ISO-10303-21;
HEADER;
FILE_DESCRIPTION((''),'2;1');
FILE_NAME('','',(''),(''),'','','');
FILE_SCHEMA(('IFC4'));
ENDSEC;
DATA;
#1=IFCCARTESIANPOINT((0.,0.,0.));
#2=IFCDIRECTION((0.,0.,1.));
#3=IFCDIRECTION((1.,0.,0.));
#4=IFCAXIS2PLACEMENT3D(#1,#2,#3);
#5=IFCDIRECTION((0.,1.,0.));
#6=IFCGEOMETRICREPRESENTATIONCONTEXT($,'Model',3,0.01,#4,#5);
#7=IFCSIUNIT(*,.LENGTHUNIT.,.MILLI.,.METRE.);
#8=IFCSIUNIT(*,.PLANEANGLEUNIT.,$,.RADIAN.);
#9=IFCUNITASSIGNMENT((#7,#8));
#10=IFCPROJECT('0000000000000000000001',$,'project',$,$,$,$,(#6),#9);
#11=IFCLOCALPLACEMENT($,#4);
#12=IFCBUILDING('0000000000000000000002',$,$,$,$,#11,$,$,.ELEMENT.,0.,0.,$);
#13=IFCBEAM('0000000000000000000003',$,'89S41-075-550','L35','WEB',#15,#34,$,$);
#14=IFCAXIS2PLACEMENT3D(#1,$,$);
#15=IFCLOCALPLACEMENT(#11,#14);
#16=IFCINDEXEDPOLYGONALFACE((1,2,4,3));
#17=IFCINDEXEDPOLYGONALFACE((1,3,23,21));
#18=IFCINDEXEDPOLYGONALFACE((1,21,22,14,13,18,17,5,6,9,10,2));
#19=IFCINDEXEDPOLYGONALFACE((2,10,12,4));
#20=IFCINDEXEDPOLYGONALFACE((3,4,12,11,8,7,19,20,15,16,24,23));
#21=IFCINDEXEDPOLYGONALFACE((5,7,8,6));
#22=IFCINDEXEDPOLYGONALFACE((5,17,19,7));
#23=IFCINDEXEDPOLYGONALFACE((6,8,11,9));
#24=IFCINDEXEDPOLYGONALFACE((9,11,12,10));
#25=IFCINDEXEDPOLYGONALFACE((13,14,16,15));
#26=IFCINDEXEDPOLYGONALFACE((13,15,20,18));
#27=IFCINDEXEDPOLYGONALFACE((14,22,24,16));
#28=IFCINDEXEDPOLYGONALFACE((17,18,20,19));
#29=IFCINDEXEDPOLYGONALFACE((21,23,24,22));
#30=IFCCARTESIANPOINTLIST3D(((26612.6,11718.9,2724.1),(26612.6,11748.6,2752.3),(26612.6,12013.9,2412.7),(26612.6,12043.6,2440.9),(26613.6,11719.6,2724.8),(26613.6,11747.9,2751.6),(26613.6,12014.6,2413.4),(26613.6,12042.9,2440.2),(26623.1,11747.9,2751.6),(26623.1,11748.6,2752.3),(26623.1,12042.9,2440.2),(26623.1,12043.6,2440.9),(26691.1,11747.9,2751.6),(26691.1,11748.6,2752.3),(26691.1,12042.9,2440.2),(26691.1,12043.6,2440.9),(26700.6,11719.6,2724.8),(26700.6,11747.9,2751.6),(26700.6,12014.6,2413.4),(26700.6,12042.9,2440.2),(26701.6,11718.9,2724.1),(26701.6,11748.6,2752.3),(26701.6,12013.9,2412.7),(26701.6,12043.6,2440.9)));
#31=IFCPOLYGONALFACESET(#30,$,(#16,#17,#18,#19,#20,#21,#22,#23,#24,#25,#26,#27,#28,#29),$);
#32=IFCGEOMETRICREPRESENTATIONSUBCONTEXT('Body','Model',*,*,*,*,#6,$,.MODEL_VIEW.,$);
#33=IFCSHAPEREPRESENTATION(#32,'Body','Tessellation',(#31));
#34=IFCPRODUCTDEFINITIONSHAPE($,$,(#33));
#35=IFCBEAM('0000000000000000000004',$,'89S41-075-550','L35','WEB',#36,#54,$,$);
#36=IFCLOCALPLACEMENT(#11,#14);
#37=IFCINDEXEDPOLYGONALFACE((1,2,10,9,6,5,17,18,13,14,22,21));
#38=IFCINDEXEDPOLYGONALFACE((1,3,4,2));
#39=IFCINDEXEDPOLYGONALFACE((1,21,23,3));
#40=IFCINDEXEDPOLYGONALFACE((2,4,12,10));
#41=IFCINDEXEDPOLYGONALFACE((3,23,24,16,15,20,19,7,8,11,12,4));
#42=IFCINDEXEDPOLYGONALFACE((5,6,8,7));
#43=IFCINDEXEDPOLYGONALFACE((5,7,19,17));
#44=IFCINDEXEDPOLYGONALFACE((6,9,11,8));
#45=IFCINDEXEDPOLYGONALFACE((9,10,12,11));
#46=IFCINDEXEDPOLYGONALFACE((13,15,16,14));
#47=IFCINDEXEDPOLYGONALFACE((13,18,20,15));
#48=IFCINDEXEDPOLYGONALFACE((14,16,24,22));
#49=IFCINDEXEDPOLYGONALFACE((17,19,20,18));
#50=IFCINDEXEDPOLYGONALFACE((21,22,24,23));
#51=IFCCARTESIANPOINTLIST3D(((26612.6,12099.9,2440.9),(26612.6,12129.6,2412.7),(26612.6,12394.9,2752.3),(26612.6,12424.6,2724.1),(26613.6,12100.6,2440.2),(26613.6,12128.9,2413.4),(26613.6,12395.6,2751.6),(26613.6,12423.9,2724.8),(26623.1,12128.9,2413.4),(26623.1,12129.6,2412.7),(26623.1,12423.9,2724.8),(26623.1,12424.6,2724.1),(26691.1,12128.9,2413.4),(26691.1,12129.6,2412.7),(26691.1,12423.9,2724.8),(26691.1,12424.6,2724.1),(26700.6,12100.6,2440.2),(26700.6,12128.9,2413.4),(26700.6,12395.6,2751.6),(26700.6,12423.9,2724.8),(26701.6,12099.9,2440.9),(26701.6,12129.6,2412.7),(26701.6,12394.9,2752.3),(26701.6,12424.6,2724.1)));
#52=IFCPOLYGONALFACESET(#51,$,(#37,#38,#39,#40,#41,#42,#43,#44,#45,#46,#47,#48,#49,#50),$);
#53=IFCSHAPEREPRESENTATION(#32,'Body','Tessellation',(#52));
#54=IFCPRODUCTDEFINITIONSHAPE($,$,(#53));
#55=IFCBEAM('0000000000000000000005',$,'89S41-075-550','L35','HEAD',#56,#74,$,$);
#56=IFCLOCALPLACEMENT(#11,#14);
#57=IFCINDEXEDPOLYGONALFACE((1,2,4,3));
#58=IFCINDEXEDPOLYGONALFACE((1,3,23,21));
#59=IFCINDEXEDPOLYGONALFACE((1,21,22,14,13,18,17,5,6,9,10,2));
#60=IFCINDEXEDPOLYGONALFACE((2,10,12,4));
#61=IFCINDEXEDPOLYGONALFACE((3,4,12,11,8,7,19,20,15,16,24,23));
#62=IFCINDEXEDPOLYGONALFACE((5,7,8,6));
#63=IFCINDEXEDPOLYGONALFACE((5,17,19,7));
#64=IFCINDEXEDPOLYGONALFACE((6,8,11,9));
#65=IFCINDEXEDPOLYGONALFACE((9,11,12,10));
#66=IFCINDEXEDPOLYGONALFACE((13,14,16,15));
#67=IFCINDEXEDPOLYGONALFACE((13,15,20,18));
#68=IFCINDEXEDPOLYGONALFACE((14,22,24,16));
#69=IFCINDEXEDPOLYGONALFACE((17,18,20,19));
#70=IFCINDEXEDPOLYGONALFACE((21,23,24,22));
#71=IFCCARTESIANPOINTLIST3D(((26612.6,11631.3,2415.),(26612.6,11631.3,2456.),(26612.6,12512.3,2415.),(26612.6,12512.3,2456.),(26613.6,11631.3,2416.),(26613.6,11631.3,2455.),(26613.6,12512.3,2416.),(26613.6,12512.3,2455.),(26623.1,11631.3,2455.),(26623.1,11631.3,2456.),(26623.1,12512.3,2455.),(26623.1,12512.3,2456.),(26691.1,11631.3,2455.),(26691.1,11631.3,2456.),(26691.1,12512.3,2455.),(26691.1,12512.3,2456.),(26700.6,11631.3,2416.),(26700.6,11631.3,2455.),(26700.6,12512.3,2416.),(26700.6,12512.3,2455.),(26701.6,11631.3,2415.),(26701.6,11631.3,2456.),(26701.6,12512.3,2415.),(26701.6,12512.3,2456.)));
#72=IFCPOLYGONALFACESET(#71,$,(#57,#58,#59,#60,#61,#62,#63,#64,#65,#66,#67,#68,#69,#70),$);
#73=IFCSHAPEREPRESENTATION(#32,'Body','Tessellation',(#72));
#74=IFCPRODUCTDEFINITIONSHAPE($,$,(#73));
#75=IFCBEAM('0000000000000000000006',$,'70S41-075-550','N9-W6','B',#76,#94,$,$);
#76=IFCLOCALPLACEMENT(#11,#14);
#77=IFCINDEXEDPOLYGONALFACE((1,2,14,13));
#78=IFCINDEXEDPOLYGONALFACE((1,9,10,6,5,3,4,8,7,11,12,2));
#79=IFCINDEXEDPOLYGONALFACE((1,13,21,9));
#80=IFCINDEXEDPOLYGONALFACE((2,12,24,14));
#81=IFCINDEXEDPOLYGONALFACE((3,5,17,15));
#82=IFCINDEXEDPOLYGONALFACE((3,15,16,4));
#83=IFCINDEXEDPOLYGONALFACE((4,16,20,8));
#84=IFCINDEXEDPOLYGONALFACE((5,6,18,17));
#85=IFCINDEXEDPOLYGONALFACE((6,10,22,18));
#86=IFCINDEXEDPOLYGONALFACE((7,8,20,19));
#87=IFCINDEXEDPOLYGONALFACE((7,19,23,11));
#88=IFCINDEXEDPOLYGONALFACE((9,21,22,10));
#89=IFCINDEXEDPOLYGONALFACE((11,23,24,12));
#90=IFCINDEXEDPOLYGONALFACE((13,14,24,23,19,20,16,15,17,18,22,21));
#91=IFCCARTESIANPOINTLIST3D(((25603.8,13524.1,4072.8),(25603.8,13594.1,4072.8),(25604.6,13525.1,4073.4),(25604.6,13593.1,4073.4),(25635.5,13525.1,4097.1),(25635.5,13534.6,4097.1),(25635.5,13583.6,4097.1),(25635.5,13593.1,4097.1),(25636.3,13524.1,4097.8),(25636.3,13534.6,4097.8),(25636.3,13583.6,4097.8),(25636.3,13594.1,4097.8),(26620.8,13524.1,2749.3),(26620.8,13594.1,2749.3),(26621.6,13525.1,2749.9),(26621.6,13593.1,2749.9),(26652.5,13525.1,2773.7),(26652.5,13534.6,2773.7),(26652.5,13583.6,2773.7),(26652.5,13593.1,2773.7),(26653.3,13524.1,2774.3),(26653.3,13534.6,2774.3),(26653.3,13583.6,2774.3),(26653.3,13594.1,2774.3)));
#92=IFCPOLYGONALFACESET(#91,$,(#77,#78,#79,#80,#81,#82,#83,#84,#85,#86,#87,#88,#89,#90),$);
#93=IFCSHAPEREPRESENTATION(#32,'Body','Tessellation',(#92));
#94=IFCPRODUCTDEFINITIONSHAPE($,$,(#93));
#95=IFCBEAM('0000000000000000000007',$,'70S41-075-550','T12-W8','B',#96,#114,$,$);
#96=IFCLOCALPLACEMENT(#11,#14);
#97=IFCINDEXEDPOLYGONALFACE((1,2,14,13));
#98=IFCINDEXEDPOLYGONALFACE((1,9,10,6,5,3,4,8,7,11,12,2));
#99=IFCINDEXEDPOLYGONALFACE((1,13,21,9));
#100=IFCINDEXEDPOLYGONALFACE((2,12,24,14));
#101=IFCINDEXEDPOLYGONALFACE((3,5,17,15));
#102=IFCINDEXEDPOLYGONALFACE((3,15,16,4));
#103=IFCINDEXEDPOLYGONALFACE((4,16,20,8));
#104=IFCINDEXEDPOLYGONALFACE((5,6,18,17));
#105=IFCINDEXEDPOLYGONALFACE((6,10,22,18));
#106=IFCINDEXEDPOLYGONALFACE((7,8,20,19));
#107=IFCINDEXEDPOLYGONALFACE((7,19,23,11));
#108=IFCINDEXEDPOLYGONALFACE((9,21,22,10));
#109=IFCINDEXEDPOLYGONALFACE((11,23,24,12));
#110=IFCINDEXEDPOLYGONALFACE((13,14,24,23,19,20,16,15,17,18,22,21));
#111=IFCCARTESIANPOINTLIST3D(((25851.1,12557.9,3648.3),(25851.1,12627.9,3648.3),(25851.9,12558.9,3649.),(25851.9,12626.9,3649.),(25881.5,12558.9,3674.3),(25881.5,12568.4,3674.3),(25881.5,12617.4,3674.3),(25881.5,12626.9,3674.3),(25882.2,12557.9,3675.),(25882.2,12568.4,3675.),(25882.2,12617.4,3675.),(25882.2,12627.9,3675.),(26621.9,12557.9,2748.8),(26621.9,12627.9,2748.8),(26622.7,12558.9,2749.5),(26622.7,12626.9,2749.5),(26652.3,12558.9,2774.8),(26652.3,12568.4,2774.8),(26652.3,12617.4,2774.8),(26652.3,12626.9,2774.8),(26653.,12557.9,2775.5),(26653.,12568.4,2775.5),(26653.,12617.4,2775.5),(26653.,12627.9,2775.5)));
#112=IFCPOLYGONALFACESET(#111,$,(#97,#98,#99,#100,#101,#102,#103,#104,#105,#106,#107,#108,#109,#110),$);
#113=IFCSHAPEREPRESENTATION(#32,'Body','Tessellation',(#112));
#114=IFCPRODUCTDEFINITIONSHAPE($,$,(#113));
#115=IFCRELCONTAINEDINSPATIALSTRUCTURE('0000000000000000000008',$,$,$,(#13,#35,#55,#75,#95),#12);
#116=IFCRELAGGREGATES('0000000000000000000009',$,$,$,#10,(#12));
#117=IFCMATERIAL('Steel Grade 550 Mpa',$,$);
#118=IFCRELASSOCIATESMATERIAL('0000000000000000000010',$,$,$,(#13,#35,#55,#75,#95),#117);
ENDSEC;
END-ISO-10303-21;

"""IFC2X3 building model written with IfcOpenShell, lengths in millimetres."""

from ifc_helpers import new_model, si_unit, direction, frame, origin, origin_with_axes, origin_2d_with_axis, place, context, subcontext, project, spatial, c_section, extrude, source, transform, mapped, material, element, save


model = new_model("IFC2X3")

# Units and contexts
model_context = context("Model", 3, precision=0.01, world=origin_with_axes(), true_north=direction((0.0, 1.0, 0.0)))
body_context = subcontext(model_context, "Body", "Model", "MODEL_VIEW")
ifc_project = project(units=[si_unit("LENGTHUNIT", "METRE", prefix="MILLI"), si_unit("PLANEANGLEUNIT", "RADIAN")], contexts=[model_context])

# Building
building_placement = place(None, origin_with_axes())
building = spatial("IfcBuilding", under=ifc_project, at=building_placement, CompositionType="ELEMENT", ElevationOfRefHeight=0.0, ElevationOfTerrain=0.0)

# Shared definitions
ifc_material = material(Name="Steel Grade 550 Mpa")

# Beams
shared_shape_1 = source(origin(), body_context, "Body", "SweptSolid", [
    extrude(c_section(Depth=89.0, Width=41.0, WallThickness=1.0, Girth=10.5, at=origin_2d_with_axis()), origin_with_axes(), (0.0, 0.0, 1.0), 429.0),
])
beam_1_placement = place(None, frame((26657.1, 12028.8, 2426.8), z_axis=(0.0, -0.687706, 0.725989), x_axis=(0.0, 0.725989, 0.687706)))
element("IfcBeam", 1, at=beam_1_placement, inside=building, material=ifc_material, Name="89S41-075-550", Description="L35", ObjectType="WEB", context=body_context, shape_type="MappedRepresentation", body=[
    mapped(shared_shape_1, transform((0.0, 0.0, 0.0), scale=1.0)),
])
shared_shape_2 = source(origin(), body_context, "Body", "SweptSolid", [
    extrude(c_section(Depth=89.0, Width=41.0, WallThickness=1.0, Girth=10.5, at=origin_2d_with_axis()), origin_with_axes(), (0.0, 0.0, 1.0), 429.0),
])
beam_2_placement = place(None, frame((26657.1, 12114.7, 2426.8), z_axis=(0.0, 0.687715, 0.725981), x_axis=(0.0, 0.725981, -0.687715)))
element("IfcBeam", 2, at=beam_2_placement, inside=building, material=ifc_material, Name="89S41-075-550", Description="L35", ObjectType="WEB", context=body_context, shape_type="MappedRepresentation", body=[
    mapped(shared_shape_2, transform((0.0, 0.0, 0.0), scale=1.0)),
])
shared_shape_3 = source(origin(), body_context, "Body", "SweptSolid", [
    extrude(c_section(Depth=89.0, Width=41.0, WallThickness=1.0, Girth=10.5, at=origin_2d_with_axis()), origin_with_axes(), (0.0, 0.0, 1.0), 881.0),
])
beam_3_placement = place(None, frame((26657.1, 12512.3, 2435.5), z_axis=(0.0, -1.0, 0.0), x_axis=(0.0, 0.0, 1.0)))
element("IfcBeam", 3, at=beam_3_placement, inside=building, material=ifc_material, Name="89S41-075-550", Description="L35", ObjectType="HEAD", context=body_context, shape_type="MappedRepresentation", body=[
    mapped(shared_shape_3, transform((0.0, 0.0, 0.0), scale=1.0)),
])
shared_shape_4 = source(origin(), body_context, "Body", "SweptSolid", [
    extrude(c_section(Depth=70.0, Width=41.0, WallThickness=1.0, Girth=10.5, at=origin_2d_with_axis()), origin_with_axes(), (0.0, 0.0, 1.0), 1669.1),
])
beam_4_placement = place(None, frame((26637.0, 13559.1, 2761.8), z_axis=(-0.609311, 0.0, 0.792931), x_axis=(0.792931, 0.0, 0.609311)))
element("IfcBeam", 4, at=beam_4_placement, inside=building, material=ifc_material, Name="70S41-075-550", Description="N9-W6", ObjectType="B", context=body_context, shape_type="MappedRepresentation", body=[
    mapped(shared_shape_4, transform((0.0, 0.0, 0.0), scale=1.0)),
])
shared_shape_5 = source(origin(), body_context, "Body", "SweptSolid", [
    extrude(c_section(Depth=70.0, Width=41.0, WallThickness=1.0, Girth=10.5, at=origin_2d_with_axis()), origin_with_axes(), (0.0, 0.0, 1.0), 1184.6),
])
beam_5_placement = place(None, frame((26637.5, 12592.9, 2762.1), z_axis=(-0.650693, 0.0, 0.75934), x_axis=(0.75934, 0.0, 0.650693)))
element("IfcBeam", 5, at=beam_5_placement, inside=building, material=ifc_material, Name="70S41-075-550", Description="T12-W8", ObjectType="B", context=body_context, shape_type="MappedRepresentation", body=[
    mapped(shared_shape_5, transform((0.0, 0.0, 0.0), scale=1.0)),
])

save(model, "model.ifc")
